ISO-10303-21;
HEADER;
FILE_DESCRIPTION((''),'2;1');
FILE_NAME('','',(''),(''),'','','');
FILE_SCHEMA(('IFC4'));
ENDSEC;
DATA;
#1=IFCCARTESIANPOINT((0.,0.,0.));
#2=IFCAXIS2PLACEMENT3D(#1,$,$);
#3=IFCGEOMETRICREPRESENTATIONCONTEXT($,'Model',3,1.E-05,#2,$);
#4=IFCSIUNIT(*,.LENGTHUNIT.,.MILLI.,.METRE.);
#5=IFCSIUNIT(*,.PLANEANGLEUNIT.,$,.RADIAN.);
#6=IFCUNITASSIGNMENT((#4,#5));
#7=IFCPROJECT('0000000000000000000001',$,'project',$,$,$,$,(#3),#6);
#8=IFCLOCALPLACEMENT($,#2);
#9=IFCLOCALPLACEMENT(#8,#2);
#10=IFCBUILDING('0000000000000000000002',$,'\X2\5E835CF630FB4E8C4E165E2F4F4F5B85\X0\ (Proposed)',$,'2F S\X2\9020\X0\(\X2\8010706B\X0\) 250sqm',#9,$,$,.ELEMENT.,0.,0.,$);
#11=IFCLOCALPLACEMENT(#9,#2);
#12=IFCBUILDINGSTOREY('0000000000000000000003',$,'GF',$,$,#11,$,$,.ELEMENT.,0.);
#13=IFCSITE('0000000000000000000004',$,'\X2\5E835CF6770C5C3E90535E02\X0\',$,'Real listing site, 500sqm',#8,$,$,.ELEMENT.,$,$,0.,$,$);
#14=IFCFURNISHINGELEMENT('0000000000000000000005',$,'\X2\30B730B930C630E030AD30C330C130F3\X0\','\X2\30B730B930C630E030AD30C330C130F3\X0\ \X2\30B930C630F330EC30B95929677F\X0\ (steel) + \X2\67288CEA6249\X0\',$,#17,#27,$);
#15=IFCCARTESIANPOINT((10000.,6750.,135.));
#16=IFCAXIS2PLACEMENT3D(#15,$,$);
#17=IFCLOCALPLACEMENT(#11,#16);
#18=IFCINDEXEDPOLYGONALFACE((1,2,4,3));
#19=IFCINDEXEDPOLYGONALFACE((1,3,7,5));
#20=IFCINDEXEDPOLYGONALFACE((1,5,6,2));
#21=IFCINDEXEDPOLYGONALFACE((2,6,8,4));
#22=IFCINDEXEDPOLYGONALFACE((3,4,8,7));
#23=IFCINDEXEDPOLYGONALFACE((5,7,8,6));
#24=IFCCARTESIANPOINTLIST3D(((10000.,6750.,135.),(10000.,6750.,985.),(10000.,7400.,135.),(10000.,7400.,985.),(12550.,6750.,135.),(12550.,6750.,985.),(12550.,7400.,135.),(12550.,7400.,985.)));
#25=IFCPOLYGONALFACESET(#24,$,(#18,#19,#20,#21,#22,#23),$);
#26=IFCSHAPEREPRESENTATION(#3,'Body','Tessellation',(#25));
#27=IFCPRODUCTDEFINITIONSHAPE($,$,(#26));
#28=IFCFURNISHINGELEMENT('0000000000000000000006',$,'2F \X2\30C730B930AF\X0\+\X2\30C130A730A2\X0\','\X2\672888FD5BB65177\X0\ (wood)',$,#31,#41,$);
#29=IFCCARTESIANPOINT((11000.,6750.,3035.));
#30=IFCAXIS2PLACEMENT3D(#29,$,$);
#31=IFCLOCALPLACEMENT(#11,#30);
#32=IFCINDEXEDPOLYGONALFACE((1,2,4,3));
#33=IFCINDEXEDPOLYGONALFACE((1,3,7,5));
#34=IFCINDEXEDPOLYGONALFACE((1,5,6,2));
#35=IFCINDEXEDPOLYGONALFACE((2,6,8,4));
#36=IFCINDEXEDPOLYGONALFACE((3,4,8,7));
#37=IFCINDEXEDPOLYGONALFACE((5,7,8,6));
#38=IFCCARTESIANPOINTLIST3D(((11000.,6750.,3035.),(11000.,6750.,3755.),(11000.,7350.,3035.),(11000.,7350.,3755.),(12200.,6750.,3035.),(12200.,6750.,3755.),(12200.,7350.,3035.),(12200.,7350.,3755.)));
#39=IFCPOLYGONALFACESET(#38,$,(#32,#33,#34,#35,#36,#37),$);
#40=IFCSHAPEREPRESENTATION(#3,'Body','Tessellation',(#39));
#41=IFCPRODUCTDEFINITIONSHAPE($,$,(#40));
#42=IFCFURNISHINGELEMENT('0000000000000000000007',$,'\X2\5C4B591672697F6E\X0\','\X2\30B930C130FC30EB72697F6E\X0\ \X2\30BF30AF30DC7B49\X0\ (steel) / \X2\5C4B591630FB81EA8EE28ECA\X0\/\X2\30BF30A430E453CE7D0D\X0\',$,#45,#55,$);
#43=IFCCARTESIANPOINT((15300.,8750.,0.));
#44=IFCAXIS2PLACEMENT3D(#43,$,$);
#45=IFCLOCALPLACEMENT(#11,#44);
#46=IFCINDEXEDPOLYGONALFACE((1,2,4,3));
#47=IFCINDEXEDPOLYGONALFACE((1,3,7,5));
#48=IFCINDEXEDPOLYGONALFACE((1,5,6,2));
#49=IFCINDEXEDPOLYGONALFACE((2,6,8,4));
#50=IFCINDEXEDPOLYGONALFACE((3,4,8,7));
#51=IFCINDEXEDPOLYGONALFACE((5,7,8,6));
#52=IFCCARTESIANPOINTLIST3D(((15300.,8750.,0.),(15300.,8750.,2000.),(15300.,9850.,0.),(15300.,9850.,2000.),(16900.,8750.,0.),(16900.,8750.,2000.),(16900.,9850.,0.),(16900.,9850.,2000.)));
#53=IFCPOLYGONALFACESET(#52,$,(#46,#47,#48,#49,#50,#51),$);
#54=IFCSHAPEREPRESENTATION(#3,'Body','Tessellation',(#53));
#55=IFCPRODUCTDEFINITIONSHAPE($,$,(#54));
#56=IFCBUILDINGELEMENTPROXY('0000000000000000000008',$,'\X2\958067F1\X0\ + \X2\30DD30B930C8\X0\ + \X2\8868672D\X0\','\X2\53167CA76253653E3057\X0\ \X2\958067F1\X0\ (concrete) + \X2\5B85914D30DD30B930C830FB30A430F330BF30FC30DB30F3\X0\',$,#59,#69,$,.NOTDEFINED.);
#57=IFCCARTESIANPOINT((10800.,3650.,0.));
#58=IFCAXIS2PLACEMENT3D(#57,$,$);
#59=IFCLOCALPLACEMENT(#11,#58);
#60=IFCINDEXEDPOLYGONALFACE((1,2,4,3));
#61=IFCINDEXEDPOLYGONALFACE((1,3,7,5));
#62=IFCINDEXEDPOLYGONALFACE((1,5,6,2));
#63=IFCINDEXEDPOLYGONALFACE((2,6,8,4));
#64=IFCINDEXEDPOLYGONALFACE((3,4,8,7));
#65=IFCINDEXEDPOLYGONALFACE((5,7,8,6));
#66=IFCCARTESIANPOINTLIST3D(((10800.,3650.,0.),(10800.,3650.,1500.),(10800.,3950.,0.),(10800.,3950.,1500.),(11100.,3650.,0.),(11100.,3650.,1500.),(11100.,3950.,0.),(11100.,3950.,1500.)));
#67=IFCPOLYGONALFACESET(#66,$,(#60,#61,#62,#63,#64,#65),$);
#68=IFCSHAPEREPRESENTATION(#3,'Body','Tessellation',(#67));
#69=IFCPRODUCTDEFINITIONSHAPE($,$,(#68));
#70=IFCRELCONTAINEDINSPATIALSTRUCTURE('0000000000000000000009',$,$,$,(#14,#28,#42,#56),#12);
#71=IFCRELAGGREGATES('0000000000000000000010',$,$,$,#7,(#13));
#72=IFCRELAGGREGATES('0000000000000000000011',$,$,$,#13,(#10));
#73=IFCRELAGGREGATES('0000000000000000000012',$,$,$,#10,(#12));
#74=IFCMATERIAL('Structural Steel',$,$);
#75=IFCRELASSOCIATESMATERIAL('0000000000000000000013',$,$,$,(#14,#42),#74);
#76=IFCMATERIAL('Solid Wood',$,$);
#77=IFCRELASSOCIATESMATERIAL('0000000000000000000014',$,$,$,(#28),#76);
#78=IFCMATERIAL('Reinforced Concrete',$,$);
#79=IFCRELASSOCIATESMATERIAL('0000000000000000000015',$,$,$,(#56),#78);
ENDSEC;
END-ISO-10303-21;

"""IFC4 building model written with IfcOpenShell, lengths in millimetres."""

from ifc_helpers import new_model, si_unit, frame, frame_2d, origin, place, context, project, spatial, rectangle, extrude, material, element, save


model = new_model("IFC4")

# Units and contexts
model_context = context("Model", 3, precision=1e-05, world=origin())
ifc_project = project(units=[si_unit("LENGTHUNIT", "METRE", prefix="MILLI"), si_unit("PLANEANGLEUNIT", "RADIAN")], contexts=[model_context])

# Site, building, storey
site_placement = place(None, origin())
site = spatial("IfcSite", under=ifc_project, at=site_placement, Name="広島県尾道市", ObjectType="Real listing site, 500sqm", CompositionType="ELEMENT", RefElevation=0.0)
building_placement = place(site_placement, origin())
building = spatial("IfcBuilding", under=site, at=building_placement, Name="広島・二世帯住宅 (Proposed)", ObjectType="2F S造(耐火) 250sqm", CompositionType="ELEMENT", ElevationOfRefHeight=0.0, ElevationOfTerrain=0.0)
storey_placement = place(building_placement, origin())
storey = spatial("IfcBuildingStorey", under=building, at=storey_placement, Name="GF", CompositionType="ELEMENT", Elevation=0.0)

# Shared definitions
ifc_material_1 = material(Name="Solid Wood")

# Shared definitions
ifc_material_2 = material(Name="Reinforced Concrete")

# Shared definitions
ifc_material_3 = material(Name="Structural Steel")

# Furnishing elements
furnishing_1_placement = place(storey_placement, frame((10000.0, 6750.0, 135.0)))
element("IfcFurnishingElement", 1, at=furnishing_1_placement, inside=storey, material=ifc_material_3, Name="システムキッチン", Description="システムキッチン ステンレス天板 (steel) + 木質扉", context=model_context, shape_type="SweptSolid", body=[
    extrude(rectangle(XDim=2550.0, YDim=650.0, at=frame_2d((1275.0, 325.0))), frame((10000.0, 6750.0, 135.0)), (0.0, 0.0, 1.0), 850.0),
])
furnishing_2_placement = place(storey_placement, frame((11000.0, 6750.0, 3035.0)))
element("IfcFurnishingElement", 2, at=furnishing_2_placement, inside=storey, material=ifc_material_1, Name="2F デスク+チェア", Description="木製家具 (wood)", context=model_context, shape_type="SweptSolid", body=[
    extrude(rectangle(XDim=1200.0, YDim=600.0, at=frame_2d((600.0, 300.0))), frame((11000.0, 6750.0, 3035.0)), (0.0, 0.0, 1.0), 720.0),
])
furnishing_3_placement = place(storey_placement, frame((15300.0, 8750.0, 0.0)))
element("IfcFurnishingElement", 3, at=furnishing_3_placement, inside=storey, material=ifc_material_3, Name="屋外物置", Description="スチール物置 タクボ等 (steel) / 屋外・自転車/タイヤ収納", context=model_context, shape_type="SweptSolid", body=[
    extrude(rectangle(XDim=1600.0, YDim=1100.0, at=frame_2d((800.0, 550.0))), frame((15300.0, 8750.0, 0.0)), (0.0, 0.0, 1.0), 2000.0),
])

# Building element proxy
proxy_placement = place(storey_placement, frame((10800.0, 3650.0, 0.0)))
element("IfcBuildingElementProxy", 4, at=proxy_placement, inside=storey, material=ifc_material_2, Name="門柱 + ポスト + 表札", Description="化粧打放し 門柱 (concrete) + 宅配ポスト・インターホン", PredefinedType="NOTDEFINED", context=model_context, shape_type="SweptSolid", body=[
    extrude(rectangle(XDim=300.0, YDim=300.0, at=frame_2d((150.0, 150.0))), frame((10800.0, 3650.0, 0.0)), (0.0, 0.0, 1.0), 1500.0),
])

save(model, "model.ifc")
